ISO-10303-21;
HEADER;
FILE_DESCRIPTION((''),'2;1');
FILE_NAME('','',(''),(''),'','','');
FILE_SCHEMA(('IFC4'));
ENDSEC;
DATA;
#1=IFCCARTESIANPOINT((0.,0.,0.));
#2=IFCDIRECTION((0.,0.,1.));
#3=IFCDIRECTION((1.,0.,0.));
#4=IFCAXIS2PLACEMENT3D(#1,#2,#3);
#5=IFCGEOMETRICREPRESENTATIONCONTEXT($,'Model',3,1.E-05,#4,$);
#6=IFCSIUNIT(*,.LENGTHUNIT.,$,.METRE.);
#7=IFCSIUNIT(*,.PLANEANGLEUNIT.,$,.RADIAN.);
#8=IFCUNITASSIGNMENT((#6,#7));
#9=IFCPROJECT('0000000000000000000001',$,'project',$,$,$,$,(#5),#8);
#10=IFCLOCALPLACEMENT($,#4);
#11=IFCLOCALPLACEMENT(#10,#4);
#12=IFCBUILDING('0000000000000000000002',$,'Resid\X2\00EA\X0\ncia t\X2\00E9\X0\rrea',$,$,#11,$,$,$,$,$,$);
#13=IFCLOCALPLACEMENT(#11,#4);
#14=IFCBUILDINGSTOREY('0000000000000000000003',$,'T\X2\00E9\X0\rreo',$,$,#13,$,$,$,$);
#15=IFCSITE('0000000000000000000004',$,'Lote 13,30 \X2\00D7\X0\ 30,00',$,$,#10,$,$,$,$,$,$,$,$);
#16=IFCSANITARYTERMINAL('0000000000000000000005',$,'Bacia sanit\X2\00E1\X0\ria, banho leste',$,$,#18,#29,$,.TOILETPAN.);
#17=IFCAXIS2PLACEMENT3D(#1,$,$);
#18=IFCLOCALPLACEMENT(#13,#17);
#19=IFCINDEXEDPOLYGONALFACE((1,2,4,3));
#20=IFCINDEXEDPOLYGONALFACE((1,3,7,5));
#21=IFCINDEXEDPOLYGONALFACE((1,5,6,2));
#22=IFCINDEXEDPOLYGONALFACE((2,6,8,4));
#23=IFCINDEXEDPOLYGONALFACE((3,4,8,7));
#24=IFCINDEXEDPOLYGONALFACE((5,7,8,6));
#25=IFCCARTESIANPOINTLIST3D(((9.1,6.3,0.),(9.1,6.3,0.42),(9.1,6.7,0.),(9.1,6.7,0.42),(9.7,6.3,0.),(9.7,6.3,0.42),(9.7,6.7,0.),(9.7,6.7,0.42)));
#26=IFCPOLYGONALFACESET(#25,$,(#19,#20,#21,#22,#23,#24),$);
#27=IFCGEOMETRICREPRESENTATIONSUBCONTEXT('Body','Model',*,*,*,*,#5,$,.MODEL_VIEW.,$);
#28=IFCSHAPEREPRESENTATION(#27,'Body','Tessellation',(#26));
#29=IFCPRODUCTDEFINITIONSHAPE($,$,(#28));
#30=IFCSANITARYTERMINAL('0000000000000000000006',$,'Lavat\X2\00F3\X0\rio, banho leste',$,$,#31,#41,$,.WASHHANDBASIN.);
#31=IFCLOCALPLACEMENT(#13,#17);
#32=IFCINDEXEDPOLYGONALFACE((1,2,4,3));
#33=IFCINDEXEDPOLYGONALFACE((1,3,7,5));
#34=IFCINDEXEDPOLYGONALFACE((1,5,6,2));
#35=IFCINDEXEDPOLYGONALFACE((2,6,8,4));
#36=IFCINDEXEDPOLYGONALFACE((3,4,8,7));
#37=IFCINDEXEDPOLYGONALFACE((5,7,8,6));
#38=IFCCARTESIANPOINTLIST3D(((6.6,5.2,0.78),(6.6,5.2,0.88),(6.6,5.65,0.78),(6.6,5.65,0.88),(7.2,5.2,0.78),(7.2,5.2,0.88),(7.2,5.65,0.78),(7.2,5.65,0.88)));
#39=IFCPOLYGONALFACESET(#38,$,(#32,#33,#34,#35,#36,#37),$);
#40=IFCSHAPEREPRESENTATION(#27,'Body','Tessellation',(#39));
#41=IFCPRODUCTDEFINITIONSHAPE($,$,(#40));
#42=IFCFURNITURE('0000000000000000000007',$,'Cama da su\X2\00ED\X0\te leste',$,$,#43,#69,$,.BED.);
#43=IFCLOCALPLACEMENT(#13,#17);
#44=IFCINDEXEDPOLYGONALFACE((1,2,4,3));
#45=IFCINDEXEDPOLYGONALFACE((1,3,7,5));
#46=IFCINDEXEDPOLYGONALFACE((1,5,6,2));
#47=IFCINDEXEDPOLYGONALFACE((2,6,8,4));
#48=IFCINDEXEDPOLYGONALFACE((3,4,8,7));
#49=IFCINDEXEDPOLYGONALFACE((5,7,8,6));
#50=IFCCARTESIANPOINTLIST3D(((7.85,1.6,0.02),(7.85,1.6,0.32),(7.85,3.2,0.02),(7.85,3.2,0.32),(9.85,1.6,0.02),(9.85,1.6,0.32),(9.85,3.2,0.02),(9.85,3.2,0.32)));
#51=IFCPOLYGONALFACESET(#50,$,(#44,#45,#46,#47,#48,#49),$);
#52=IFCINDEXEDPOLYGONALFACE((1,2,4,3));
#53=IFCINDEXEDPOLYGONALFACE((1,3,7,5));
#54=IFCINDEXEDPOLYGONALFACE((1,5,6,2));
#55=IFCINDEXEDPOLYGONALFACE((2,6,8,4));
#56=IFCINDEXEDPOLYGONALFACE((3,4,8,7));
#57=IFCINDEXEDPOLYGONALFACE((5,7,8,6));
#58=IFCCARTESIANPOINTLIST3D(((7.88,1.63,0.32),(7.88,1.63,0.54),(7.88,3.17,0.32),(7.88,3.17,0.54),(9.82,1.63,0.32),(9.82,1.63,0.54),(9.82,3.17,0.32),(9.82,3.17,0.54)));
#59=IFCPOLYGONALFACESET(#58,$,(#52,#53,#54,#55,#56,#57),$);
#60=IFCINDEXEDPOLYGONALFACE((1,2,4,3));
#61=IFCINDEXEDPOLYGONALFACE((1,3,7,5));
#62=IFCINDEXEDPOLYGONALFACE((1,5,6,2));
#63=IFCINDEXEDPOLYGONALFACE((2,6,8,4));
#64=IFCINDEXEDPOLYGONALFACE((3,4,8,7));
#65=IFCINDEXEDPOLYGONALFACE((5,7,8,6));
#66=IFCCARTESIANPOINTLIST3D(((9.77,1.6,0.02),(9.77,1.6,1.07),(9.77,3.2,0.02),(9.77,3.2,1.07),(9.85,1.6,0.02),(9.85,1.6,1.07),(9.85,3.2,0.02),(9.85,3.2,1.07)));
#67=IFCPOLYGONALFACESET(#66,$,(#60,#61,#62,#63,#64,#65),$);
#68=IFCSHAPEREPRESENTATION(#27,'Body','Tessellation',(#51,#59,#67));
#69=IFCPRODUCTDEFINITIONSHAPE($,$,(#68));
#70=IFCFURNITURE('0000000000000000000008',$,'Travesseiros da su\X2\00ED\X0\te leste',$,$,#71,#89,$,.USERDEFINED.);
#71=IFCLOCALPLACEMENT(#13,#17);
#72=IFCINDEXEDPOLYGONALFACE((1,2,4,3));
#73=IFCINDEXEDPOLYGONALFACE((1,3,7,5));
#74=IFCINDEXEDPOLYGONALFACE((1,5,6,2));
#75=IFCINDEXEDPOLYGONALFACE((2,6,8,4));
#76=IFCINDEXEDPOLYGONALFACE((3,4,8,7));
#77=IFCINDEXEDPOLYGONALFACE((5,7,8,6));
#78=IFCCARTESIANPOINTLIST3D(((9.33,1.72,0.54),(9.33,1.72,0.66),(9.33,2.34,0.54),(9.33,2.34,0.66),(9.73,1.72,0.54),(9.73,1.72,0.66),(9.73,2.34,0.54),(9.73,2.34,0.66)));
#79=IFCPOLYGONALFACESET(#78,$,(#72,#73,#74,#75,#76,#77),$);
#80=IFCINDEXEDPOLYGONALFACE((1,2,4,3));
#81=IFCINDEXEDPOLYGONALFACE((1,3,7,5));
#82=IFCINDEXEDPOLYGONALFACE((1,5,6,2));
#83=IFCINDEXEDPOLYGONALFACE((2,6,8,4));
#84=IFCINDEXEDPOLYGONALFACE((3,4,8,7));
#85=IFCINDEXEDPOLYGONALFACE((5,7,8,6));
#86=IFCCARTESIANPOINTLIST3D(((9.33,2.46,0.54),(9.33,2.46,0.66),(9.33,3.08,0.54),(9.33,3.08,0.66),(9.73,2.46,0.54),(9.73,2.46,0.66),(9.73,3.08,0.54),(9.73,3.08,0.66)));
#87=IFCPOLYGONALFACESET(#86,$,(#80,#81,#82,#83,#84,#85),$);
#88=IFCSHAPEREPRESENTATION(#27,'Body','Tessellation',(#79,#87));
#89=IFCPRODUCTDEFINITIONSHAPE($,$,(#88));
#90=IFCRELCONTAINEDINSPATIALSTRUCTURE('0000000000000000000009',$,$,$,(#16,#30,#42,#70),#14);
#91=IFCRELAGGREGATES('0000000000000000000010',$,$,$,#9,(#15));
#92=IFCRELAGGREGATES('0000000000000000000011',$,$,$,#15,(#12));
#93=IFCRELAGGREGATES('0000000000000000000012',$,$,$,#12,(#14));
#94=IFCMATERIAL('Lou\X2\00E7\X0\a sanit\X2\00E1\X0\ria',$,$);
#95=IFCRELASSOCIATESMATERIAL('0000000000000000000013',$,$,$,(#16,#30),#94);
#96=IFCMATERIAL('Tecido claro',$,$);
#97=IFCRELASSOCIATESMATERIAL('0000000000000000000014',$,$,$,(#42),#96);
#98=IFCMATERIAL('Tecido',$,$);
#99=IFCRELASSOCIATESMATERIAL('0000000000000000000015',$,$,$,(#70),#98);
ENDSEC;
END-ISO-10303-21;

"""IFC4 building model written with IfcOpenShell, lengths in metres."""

from ifc_helpers import new_model, si_unit, frame, origin_with_axes, place, context, subcontext, project, spatial, line, indexed_curve, outline, extrude, material, element, save


model = new_model("IFC4")

# Units and contexts
model_context = context("Model", 3, precision=1e-05, world=origin_with_axes())
body_context = subcontext(model_context, "Body", "Model", "MODEL_VIEW")
ifc_project = project(units=[si_unit("LENGTHUNIT", "METRE"), si_unit("PLANEANGLEUNIT", "RADIAN")], contexts=[model_context])

# Site, building, storey
site_placement = place(None, origin_with_axes())
site = spatial("IfcSite", under=ifc_project, at=site_placement, Name="Lote 13,30 × 30,00")
building_placement = place(site_placement, origin_with_axes())
building = spatial("IfcBuilding", under=site, at=building_placement, Name="Residência térrea")
storey_placement = place(building_placement, origin_with_axes())
storey = spatial("IfcBuildingStorey", under=building, at=storey_placement, Name="Térreo")

# Sanitary terminals
ifc_material_1 = material(Name="Louça sanitária")
sanitary_terminal_1_placement = place(storey_placement, frame((9.1, 6.3, 0.0), z_axis=(0.0, 0.0, 1.0), x_axis=(1.0, 0.0, 0.0)))
element("IfcSanitaryTerminal", 1, at=sanitary_terminal_1_placement, inside=storey, material=ifc_material_1, Name="Bacia sanitária, banho leste", PredefinedType="TOILETPAN", context=body_context, shape_type="SweptSolid", body=[
    extrude(outline(indexed_curve([(0.0, 0.0), (0.6, 0.0), (0.6, 0.4), (0.0, 0.4)], segments=[line(1, 2, 3, 4, 1)])), origin_with_axes(), (0.0, 0.0, 1.0), 0.42),
])
sanitary_terminal_2_placement = place(storey_placement, frame((6.6, 5.2, 0.78), z_axis=(0.0, 0.0, 1.0), x_axis=(1.0, 0.0, 0.0)))
element("IfcSanitaryTerminal", 2, at=sanitary_terminal_2_placement, inside=storey, material=ifc_material_1, Name="Lavatório, banho leste", PredefinedType="WASHHANDBASIN", context=body_context, shape_type="SweptSolid", body=[
    extrude(outline(indexed_curve([(0.0, 0.0), (0.6, 0.0), (0.6, 0.45), (0.0, 0.45)], segments=[line(1, 2, 3, 4, 1)])), origin_with_axes(), (0.0, 0.0, 1.0), 0.1),
])

# Furniture
ifc_material_2 = material(Name="Tecido claro")
furniture_1_placement = place(storey_placement, frame((7.85, 1.6, 0.02), z_axis=(0.0, 0.0, 1.0), x_axis=(1.0, 0.0, 0.0)))
element("IfcFurniture", 3, at=furniture_1_placement, inside=storey, material=ifc_material_2, Name="Cama da suíte leste", PredefinedType="BED", context=body_context, shape_type="SweptSolid", body=[
    extrude(outline(indexed_curve([(0.0, 0.0), (2.0, 0.0), (2.0, 1.6), (0.0, 1.6)], segments=[line(1, 2, 3, 4, 1)])), origin_with_axes(), (0.0, 0.0, 1.0), 0.3),
    extrude(outline(indexed_curve([(0.03, 0.03), (1.97, 0.03), (1.97, 1.57), (0.03, 1.57)], segments=[line(1, 2, 3, 4, 1)])), frame((0.0, 0.0, 0.3), z_axis=(0.0, 0.0, 1.0), x_axis=(1.0, 0.0, 0.0)), (0.0, 0.0, 1.0), 0.22),
    extrude(outline(indexed_curve([(1.92, 0.0), (2.0, 0.0), (2.0, 1.6), (1.92, 1.6)], segments=[line(1, 2, 3, 4, 1)])), origin_with_axes(), (0.0, 0.0, 1.0), 1.05),
])
ifc_material_3 = material(Name="Tecido")
furniture_2_placement = place(storey_placement, frame((9.33, 1.72, 0.54), z_axis=(0.0, 0.0, 1.0), x_axis=(1.0, 0.0, 0.0)))
element("IfcFurniture", 4, at=furniture_2_placement, inside=storey, material=ifc_material_3, Name="Travesseiros da suíte leste", PredefinedType="USERDEFINED", context=body_context, shape_type="SweptSolid", body=[
    extrude(outline(indexed_curve([(0.0, 0.0), (0.4, 0.0), (0.4, 0.62), (0.0, 0.62)], segments=[line(1, 2, 3, 4, 1)])), origin_with_axes(), (0.0, 0.0, 1.0), 0.12),
    extrude(outline(indexed_curve([(0.0, 0.74), (0.4, 0.74), (0.4, 1.36), (0.0, 1.36)], segments=[line(1, 2, 3, 4, 1)])), origin_with_axes(), (0.0, 0.0, 1.0), 0.12),
])

save(model, "model.ifc")
